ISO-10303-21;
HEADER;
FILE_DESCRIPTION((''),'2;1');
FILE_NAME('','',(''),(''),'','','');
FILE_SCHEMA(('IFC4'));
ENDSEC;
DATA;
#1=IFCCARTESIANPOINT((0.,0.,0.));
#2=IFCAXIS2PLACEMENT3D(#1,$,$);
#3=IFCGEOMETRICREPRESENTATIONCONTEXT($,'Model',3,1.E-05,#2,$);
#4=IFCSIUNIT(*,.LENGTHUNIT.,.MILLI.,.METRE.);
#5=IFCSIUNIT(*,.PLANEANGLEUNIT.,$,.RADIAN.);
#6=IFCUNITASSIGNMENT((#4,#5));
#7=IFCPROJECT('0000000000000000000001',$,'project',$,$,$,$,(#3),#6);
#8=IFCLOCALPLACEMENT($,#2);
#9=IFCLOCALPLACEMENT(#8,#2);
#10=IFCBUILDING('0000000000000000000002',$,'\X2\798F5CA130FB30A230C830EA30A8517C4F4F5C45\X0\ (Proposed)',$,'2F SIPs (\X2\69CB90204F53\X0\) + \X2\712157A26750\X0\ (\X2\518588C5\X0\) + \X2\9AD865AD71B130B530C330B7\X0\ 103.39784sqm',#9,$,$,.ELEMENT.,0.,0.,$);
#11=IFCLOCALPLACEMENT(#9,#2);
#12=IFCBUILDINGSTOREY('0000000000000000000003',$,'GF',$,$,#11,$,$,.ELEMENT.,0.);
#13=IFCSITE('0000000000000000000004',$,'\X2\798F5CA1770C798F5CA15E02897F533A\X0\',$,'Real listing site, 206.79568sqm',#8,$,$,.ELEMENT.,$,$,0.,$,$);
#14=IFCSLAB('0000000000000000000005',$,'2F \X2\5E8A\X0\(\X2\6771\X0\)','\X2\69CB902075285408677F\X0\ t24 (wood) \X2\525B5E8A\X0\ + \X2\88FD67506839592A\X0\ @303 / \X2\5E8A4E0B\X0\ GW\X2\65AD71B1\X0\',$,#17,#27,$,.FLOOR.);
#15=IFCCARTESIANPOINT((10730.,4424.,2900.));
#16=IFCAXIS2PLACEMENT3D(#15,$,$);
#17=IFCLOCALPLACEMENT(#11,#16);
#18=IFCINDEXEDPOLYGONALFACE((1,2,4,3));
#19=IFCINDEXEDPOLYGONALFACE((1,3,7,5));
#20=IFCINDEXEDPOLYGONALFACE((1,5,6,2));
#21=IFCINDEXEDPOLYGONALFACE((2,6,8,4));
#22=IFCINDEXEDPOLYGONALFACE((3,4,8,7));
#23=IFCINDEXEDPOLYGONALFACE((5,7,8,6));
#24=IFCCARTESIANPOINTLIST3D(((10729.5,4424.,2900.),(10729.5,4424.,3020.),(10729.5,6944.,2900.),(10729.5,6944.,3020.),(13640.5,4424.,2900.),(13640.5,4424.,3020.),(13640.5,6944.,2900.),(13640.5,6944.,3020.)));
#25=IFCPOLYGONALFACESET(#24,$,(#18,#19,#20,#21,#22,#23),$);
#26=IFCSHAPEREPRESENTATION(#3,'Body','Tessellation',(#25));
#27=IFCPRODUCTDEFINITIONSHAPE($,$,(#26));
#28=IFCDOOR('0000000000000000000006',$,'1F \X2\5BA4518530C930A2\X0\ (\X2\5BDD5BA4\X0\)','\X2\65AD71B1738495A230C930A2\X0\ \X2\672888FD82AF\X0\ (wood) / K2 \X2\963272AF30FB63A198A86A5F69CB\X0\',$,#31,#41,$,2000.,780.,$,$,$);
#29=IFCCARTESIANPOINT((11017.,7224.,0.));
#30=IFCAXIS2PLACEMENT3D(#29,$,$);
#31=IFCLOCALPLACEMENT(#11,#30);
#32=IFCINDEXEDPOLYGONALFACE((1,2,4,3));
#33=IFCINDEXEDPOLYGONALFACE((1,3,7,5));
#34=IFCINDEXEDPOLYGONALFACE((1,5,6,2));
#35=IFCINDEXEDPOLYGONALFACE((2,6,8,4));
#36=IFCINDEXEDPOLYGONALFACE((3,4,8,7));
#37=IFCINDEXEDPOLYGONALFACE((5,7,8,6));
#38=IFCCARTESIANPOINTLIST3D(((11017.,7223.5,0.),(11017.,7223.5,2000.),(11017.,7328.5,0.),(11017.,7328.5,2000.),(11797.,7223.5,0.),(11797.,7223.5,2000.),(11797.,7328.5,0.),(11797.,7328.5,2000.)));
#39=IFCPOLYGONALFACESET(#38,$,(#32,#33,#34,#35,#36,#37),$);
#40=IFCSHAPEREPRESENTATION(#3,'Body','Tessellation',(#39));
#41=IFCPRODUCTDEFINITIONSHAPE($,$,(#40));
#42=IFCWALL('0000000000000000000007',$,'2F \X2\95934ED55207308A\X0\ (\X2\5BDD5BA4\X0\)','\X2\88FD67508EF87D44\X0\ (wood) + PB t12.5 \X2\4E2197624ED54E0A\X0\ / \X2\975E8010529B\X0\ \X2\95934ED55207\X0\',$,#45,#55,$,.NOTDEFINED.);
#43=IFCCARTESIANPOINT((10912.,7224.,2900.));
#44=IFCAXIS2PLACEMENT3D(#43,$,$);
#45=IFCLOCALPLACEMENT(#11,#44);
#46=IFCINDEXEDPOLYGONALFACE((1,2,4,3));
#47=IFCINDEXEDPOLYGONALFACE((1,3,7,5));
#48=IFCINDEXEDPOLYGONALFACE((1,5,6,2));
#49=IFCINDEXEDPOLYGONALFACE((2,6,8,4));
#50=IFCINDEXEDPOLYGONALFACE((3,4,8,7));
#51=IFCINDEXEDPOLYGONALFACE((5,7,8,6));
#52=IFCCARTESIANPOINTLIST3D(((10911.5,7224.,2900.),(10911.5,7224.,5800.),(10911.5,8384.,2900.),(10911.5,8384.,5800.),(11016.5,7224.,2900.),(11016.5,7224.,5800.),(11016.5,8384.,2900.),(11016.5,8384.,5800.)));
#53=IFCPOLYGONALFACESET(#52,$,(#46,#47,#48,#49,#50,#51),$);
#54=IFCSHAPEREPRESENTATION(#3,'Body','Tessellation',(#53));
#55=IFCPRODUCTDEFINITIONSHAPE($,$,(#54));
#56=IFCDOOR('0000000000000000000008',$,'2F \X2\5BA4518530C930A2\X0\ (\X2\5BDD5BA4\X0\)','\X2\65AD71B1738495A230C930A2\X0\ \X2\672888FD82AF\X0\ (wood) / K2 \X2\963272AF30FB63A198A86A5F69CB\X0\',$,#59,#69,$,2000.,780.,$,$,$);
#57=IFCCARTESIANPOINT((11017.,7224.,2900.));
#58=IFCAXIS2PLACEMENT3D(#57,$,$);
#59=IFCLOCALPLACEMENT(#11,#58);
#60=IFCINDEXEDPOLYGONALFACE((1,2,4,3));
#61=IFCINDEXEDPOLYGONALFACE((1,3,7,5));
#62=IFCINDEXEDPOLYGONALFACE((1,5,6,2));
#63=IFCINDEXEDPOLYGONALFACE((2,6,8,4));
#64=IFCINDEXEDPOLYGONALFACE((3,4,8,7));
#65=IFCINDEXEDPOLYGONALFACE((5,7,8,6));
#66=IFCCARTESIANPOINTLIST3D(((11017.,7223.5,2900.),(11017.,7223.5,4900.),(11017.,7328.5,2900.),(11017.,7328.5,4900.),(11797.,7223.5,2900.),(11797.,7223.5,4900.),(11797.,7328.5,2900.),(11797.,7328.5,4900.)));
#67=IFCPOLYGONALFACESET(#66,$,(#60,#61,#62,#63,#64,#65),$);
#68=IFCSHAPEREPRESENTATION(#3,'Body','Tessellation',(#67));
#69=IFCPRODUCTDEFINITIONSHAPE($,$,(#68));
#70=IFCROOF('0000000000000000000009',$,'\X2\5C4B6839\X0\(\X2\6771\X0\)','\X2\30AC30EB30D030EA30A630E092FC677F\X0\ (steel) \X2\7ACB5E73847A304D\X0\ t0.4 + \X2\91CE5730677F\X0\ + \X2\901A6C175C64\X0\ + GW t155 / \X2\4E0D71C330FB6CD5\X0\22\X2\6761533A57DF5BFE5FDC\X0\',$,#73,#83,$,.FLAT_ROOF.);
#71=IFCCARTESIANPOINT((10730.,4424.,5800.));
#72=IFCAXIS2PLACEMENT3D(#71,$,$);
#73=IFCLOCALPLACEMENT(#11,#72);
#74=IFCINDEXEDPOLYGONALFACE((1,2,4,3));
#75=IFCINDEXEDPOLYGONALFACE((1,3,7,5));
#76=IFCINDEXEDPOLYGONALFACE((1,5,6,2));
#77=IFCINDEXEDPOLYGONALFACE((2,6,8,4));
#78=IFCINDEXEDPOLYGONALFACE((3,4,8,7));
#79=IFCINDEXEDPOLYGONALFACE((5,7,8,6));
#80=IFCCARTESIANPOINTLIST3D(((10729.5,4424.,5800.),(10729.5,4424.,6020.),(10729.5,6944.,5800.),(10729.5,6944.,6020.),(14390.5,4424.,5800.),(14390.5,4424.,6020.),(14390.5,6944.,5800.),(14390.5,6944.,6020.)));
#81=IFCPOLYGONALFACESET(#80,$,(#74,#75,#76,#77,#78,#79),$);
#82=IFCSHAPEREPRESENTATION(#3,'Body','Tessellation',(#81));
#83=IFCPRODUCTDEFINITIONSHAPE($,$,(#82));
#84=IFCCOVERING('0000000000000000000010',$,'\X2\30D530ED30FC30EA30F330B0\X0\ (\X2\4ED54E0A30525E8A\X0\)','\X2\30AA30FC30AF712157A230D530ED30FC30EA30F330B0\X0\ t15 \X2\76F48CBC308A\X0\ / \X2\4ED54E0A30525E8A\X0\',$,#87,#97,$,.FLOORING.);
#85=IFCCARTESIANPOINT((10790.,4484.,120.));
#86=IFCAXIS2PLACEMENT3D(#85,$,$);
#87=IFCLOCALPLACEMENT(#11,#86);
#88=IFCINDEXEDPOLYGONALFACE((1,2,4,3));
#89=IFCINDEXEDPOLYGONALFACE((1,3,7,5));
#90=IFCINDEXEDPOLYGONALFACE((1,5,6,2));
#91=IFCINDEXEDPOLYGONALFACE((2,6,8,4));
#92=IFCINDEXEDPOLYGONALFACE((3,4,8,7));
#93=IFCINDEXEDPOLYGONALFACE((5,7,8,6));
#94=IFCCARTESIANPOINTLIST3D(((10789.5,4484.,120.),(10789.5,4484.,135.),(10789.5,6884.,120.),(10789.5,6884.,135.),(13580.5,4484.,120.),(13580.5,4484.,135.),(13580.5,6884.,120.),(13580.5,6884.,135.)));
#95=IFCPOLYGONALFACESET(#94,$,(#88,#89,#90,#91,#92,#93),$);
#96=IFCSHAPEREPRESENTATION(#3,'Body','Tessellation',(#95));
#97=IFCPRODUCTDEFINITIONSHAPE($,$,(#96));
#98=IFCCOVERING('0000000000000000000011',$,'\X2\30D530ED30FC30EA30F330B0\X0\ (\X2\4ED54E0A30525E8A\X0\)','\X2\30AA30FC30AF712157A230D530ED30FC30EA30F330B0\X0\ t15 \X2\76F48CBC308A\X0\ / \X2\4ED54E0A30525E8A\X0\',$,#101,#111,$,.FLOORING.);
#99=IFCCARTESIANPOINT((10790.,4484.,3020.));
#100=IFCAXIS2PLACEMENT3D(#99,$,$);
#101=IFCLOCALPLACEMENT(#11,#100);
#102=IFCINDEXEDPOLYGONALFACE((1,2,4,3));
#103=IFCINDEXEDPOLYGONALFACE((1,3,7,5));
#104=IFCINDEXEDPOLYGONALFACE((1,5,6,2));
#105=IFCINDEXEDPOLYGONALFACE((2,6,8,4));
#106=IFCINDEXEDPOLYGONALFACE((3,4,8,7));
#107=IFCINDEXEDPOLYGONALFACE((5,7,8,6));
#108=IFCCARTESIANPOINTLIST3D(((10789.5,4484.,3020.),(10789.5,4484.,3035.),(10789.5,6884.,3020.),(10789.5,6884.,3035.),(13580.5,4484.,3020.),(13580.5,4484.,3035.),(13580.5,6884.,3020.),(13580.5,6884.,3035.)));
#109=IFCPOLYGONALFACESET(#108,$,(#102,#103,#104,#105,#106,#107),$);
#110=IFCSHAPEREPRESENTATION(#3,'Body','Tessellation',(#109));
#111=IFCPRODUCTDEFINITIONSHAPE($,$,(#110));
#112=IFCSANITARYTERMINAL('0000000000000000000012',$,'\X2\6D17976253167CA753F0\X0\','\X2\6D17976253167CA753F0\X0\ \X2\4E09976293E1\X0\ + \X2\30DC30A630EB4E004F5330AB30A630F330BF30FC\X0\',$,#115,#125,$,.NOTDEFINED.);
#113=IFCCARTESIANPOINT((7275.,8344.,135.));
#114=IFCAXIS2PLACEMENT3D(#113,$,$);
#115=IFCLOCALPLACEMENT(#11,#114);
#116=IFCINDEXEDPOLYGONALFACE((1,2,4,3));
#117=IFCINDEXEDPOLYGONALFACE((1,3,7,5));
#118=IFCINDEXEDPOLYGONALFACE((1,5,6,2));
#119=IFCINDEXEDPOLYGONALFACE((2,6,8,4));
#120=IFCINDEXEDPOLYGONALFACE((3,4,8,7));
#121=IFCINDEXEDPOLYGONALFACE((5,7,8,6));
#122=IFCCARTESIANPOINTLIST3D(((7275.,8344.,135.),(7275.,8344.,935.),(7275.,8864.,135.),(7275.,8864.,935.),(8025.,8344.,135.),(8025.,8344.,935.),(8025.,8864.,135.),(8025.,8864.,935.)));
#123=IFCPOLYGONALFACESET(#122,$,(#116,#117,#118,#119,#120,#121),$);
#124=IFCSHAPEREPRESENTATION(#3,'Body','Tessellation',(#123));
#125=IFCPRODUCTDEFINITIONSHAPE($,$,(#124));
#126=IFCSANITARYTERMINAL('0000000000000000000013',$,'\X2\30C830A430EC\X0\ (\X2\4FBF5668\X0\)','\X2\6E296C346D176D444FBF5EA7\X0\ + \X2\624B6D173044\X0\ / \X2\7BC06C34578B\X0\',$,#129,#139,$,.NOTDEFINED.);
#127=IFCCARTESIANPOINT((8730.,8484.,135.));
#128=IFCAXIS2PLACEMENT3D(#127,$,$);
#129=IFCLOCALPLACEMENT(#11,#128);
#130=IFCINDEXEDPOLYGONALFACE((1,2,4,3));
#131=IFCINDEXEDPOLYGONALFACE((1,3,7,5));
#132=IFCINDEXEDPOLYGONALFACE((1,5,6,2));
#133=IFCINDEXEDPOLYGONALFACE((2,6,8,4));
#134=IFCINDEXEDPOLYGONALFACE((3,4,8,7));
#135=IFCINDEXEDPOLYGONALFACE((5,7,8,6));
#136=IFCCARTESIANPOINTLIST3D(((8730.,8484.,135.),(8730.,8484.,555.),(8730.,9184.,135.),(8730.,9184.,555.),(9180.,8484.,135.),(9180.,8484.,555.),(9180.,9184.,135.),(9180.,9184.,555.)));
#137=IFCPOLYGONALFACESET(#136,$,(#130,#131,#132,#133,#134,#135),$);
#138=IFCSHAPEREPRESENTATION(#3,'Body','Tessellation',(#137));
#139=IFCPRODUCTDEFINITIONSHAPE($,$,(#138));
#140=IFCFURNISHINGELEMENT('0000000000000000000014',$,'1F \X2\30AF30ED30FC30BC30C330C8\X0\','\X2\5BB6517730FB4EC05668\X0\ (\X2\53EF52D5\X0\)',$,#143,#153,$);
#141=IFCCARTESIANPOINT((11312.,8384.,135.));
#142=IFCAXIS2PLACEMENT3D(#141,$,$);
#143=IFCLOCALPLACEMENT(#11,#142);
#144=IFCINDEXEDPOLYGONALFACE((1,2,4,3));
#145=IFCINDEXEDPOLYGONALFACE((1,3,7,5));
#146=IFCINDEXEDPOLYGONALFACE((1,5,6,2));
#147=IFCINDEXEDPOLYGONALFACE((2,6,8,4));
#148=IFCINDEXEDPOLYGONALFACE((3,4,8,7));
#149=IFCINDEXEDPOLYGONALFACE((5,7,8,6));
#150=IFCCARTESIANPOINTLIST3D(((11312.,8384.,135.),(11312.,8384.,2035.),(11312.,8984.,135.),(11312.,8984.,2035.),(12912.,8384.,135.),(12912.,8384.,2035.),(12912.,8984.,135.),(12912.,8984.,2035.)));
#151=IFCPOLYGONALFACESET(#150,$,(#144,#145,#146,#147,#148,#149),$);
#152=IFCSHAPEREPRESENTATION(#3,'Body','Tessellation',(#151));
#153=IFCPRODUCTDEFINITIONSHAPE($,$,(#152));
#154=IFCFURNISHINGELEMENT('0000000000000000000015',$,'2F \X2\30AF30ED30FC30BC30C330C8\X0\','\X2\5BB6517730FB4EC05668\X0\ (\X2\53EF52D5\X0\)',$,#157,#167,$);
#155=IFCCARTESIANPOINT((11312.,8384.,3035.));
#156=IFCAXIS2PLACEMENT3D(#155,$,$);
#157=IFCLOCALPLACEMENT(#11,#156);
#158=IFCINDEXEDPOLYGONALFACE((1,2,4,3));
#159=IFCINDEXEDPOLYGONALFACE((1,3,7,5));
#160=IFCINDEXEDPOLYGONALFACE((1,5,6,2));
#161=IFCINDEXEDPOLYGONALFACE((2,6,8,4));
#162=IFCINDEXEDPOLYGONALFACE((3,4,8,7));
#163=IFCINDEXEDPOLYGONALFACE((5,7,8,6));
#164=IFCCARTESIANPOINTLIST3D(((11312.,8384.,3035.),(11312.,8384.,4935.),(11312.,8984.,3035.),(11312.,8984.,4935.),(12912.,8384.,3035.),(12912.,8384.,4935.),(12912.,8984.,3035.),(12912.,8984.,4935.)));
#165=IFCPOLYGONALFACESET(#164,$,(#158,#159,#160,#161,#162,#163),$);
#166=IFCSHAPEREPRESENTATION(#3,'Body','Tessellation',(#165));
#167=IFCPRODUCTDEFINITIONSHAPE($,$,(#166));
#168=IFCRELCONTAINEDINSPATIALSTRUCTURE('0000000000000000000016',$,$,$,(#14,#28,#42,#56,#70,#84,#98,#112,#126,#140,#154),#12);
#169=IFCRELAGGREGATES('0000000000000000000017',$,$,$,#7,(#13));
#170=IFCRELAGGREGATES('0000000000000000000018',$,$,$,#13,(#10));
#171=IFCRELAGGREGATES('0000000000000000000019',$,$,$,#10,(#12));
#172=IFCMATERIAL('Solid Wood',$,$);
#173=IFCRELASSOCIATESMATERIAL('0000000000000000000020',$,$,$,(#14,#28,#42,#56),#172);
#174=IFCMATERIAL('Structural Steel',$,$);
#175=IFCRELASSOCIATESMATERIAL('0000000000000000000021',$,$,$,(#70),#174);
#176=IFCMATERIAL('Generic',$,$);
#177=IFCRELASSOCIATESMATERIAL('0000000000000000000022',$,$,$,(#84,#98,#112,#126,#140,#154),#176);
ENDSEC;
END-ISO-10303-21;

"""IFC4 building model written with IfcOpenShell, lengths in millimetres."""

from ifc_helpers import new_model, si_unit, frame, frame_2d, origin, place, context, project, spatial, rectangle, extrude, material, element, save


model = new_model("IFC4")

# Units and contexts
model_context = context("Model", 3, precision=1e-05, world=origin())
ifc_project = project(units=[si_unit("LENGTHUNIT", "METRE", prefix="MILLI"), si_unit("PLANEANGLEUNIT", "RADIAN")], contexts=[model_context])

# Site, building, storey
site_placement = place(None, origin())
site = spatial("IfcSite", under=ifc_project, at=site_placement, Name="福岡県福岡市西区", ObjectType="Real listing site, 206.79568sqm", CompositionType="ELEMENT", RefElevation=0.0)
building_placement = place(site_placement, origin())
building = spatial("IfcBuilding", under=site, at=building_placement, Name="福岡・アトリエ兼住居 (Proposed)", ObjectType="2F SIPs (構造体) + 無垢材 (内装) + 高断熱サッシ 103.39784sqm", CompositionType="ELEMENT", ElevationOfRefHeight=0.0, ElevationOfTerrain=0.0)
storey_placement = place(building_placement, origin())
storey = spatial("IfcBuildingStorey", under=building, at=storey_placement, Name="GF", CompositionType="ELEMENT", Elevation=0.0)

# Slab
ifc_material_1 = material(Name="Solid Wood")
slab_1_placement = place(storey_placement, frame((10730.0, 4424.0, 2900.0)))
element("IfcSlab", 1, at=slab_1_placement, inside=storey, material=ifc_material_1, Name="2F 床(東)", Description="構造用合板 t24 (wood) 剛床 + 製材根太 @303 / 床下 GW断熱", PredefinedType="FLOOR", context=model_context, shape_type="SweptSolid", body=[
    extrude(rectangle(XDim=2911.0, YDim=2520.0, at=frame_2d((1455.0, 1260.0))), frame((10730.0, 4424.0, 2900.0)), (0.0, 0.0, 1.0), 120.0),
])

# Door
door_1_placement = place(storey_placement, frame((11017.0, 7224.0, 0.0)))
element("IfcDoor", 2, at=door_1_placement, inside=storey, material=ifc_material_1, Name="1F 室内ドア (寝室)", Description="断熱玄関ドア 木製芯 (wood) / K2 防犯・採風機構", OverallHeight=2000.0, OverallWidth=780.0, context=model_context, shape_type="SweptSolid", body=[
    extrude(rectangle(XDim=780.0, YDim=105.0, at=frame_2d((390.0, 52.0))), frame((11017.0, 7224.0, 0.0)), (0.0, 0.0, 1.0), 2000.0),
])

# Wall
wall_1_placement = place(storey_placement, frame((10912.0, 7224.0, 2900.0)))
element("IfcWall", 3, at=wall_1_placement, inside=storey, material=ifc_material_1, Name="2F 間仕切り (寝室)", Description="製材軸組 (wood) + PB t12.5 両面仕上 / 非耐力 間仕切", PredefinedType="NOTDEFINED", context=model_context, shape_type="SweptSolid", body=[
    extrude(rectangle(XDim=105.0, YDim=1160.0, at=frame_2d((52.0, 580.0))), frame((10912.0, 7224.0, 2900.0)), (0.0, 0.0, 1.0), 2900.0),
])

# Door
door_2_placement = place(storey_placement, frame((11017.0, 7224.0, 2900.0)))
element("IfcDoor", 4, at=door_2_placement, inside=storey, material=ifc_material_1, Name="2F 室内ドア (寝室)", Description="断熱玄関ドア 木製芯 (wood) / K2 防犯・採風機構", OverallHeight=2000.0, OverallWidth=780.0, context=model_context, shape_type="SweptSolid", body=[
    extrude(rectangle(XDim=780.0, YDim=105.0, at=frame_2d((390.0, 52.0))), frame((11017.0, 7224.0, 2900.0)), (0.0, 0.0, 1.0), 2000.0),
])

# Roof
ifc_material_2 = material(Name="Structural Steel")
for number, where, name in (
    (5, (10730.0, 4424.0, 5800.0), "屋根(東)"),
):
    element("IfcRoof", number, at=place(storey_placement, frame(where)), inside=storey, material=ifc_material_2, Name=name, Description="ガルバリウム鋼板 (steel) 立平葺き t0.4 + 野地板 + 通気層 + GW t155 / 不燃・法22条区域対応", PredefinedType="FLAT_ROOF", context=model_context, shape_type="SweptSolid", body=[
        extrude(rectangle(XDim=3661.0, YDim=2520.0, at=frame_2d((1830.0, 1260.0))), frame((10730.0, 4424.0, 5800.0)), (0.0, 0.0, 1.0), 220.0),
    ])

# Coverings
ifc_material_3 = material(Name="Generic")
covering_1_placement = place(storey_placement, frame((10790.0, 4484.0, 120.0)))
element("IfcCovering", 6, at=covering_1_placement, inside=storey, material=ifc_material_3, Name="フローリング (仕上げ床)", Description="オーク無垢フローリング t15 直貼り / 仕上げ床", PredefinedType="FLOORING", context=model_context, shape_type="SweptSolid", body=[
    extrude(rectangle(XDim=2791.0, YDim=2400.0, at=frame_2d((1395.0, 1200.0))), frame((10790.0, 4484.0, 120.0)), (0.0, 0.0, 1.0), 15.0),
])
covering_2_placement = place(storey_placement, frame((10790.0, 4484.0, 3020.0)))
element("IfcCovering", 7, at=covering_2_placement, inside=storey, material=ifc_material_3, Name="フローリング (仕上げ床)", Description="オーク無垢フローリング t15 直貼り / 仕上げ床", PredefinedType="FLOORING", context=model_context, shape_type="SweptSolid", body=[
    extrude(rectangle(XDim=2791.0, YDim=2400.0, at=frame_2d((1395.0, 1200.0))), frame((10790.0, 4484.0, 3020.0)), (0.0, 0.0, 1.0), 15.0),
])

# Sanitary terminals
sanitary_terminal_1_placement = place(storey_placement, frame((7275.0, 8344.0, 135.0)))
element("IfcSanitaryTerminal", 8, at=sanitary_terminal_1_placement, inside=storey, material=ifc_material_3, Name="洗面化粧台", Description="洗面化粧台 三面鏡 + ボウル一体カウンター", PredefinedType="NOTDEFINED", context=model_context, shape_type="SweptSolid", body=[
    extrude(rectangle(XDim=750.0, YDim=520.0, at=frame_2d((375.0, 260.0))), frame((7275.0, 8344.0, 135.0)), (0.0, 0.0, 1.0), 800.0),
])
sanitary_terminal_2_placement = place(storey_placement, frame((8730.0, 8484.0, 135.0)))
element("IfcSanitaryTerminal", 9, at=sanitary_terminal_2_placement, inside=storey, material=ifc_material_3, Name="トイレ (便器)", Description="温水洗浄便座 + 手洗い / 節水型", PredefinedType="NOTDEFINED", context=model_context, shape_type="SweptSolid", body=[
    extrude(rectangle(XDim=450.0, YDim=700.0, at=frame_2d((225.0, 350.0))), frame((8730.0, 8484.0, 135.0)), (0.0, 0.0, 1.0), 420.0),
])

# Furnishing elements
furnishing_1_placement = place(storey_placement, frame((11312.0, 8384.0, 135.0)))
element("IfcFurnishingElement", 10, at=furnishing_1_placement, inside=storey, material=ifc_material_3, Name="1F クローゼット", Description="家具・什器 (可動)", context=model_context, shape_type="SweptSolid", body=[
    extrude(rectangle(XDim=1600.0, YDim=600.0, at=frame_2d((800.0, 300.0))), frame((11312.0, 8384.0, 135.0)), (0.0, 0.0, 1.0), 1900.0),
])
furnishing_2_placement = place(storey_placement, frame((11312.0, 8384.0, 3035.0)))
element("IfcFurnishingElement", 11, at=furnishing_2_placement, inside=storey, material=ifc_material_3, Name="2F クローゼット", Description="家具・什器 (可動)", context=model_context, shape_type="SweptSolid", body=[
    extrude(rectangle(XDim=1600.0, YDim=600.0, at=frame_2d((800.0, 300.0))), frame((11312.0, 8384.0, 3035.0)), (0.0, 0.0, 1.0), 1900.0),
])

save(model, "model.ifc")
